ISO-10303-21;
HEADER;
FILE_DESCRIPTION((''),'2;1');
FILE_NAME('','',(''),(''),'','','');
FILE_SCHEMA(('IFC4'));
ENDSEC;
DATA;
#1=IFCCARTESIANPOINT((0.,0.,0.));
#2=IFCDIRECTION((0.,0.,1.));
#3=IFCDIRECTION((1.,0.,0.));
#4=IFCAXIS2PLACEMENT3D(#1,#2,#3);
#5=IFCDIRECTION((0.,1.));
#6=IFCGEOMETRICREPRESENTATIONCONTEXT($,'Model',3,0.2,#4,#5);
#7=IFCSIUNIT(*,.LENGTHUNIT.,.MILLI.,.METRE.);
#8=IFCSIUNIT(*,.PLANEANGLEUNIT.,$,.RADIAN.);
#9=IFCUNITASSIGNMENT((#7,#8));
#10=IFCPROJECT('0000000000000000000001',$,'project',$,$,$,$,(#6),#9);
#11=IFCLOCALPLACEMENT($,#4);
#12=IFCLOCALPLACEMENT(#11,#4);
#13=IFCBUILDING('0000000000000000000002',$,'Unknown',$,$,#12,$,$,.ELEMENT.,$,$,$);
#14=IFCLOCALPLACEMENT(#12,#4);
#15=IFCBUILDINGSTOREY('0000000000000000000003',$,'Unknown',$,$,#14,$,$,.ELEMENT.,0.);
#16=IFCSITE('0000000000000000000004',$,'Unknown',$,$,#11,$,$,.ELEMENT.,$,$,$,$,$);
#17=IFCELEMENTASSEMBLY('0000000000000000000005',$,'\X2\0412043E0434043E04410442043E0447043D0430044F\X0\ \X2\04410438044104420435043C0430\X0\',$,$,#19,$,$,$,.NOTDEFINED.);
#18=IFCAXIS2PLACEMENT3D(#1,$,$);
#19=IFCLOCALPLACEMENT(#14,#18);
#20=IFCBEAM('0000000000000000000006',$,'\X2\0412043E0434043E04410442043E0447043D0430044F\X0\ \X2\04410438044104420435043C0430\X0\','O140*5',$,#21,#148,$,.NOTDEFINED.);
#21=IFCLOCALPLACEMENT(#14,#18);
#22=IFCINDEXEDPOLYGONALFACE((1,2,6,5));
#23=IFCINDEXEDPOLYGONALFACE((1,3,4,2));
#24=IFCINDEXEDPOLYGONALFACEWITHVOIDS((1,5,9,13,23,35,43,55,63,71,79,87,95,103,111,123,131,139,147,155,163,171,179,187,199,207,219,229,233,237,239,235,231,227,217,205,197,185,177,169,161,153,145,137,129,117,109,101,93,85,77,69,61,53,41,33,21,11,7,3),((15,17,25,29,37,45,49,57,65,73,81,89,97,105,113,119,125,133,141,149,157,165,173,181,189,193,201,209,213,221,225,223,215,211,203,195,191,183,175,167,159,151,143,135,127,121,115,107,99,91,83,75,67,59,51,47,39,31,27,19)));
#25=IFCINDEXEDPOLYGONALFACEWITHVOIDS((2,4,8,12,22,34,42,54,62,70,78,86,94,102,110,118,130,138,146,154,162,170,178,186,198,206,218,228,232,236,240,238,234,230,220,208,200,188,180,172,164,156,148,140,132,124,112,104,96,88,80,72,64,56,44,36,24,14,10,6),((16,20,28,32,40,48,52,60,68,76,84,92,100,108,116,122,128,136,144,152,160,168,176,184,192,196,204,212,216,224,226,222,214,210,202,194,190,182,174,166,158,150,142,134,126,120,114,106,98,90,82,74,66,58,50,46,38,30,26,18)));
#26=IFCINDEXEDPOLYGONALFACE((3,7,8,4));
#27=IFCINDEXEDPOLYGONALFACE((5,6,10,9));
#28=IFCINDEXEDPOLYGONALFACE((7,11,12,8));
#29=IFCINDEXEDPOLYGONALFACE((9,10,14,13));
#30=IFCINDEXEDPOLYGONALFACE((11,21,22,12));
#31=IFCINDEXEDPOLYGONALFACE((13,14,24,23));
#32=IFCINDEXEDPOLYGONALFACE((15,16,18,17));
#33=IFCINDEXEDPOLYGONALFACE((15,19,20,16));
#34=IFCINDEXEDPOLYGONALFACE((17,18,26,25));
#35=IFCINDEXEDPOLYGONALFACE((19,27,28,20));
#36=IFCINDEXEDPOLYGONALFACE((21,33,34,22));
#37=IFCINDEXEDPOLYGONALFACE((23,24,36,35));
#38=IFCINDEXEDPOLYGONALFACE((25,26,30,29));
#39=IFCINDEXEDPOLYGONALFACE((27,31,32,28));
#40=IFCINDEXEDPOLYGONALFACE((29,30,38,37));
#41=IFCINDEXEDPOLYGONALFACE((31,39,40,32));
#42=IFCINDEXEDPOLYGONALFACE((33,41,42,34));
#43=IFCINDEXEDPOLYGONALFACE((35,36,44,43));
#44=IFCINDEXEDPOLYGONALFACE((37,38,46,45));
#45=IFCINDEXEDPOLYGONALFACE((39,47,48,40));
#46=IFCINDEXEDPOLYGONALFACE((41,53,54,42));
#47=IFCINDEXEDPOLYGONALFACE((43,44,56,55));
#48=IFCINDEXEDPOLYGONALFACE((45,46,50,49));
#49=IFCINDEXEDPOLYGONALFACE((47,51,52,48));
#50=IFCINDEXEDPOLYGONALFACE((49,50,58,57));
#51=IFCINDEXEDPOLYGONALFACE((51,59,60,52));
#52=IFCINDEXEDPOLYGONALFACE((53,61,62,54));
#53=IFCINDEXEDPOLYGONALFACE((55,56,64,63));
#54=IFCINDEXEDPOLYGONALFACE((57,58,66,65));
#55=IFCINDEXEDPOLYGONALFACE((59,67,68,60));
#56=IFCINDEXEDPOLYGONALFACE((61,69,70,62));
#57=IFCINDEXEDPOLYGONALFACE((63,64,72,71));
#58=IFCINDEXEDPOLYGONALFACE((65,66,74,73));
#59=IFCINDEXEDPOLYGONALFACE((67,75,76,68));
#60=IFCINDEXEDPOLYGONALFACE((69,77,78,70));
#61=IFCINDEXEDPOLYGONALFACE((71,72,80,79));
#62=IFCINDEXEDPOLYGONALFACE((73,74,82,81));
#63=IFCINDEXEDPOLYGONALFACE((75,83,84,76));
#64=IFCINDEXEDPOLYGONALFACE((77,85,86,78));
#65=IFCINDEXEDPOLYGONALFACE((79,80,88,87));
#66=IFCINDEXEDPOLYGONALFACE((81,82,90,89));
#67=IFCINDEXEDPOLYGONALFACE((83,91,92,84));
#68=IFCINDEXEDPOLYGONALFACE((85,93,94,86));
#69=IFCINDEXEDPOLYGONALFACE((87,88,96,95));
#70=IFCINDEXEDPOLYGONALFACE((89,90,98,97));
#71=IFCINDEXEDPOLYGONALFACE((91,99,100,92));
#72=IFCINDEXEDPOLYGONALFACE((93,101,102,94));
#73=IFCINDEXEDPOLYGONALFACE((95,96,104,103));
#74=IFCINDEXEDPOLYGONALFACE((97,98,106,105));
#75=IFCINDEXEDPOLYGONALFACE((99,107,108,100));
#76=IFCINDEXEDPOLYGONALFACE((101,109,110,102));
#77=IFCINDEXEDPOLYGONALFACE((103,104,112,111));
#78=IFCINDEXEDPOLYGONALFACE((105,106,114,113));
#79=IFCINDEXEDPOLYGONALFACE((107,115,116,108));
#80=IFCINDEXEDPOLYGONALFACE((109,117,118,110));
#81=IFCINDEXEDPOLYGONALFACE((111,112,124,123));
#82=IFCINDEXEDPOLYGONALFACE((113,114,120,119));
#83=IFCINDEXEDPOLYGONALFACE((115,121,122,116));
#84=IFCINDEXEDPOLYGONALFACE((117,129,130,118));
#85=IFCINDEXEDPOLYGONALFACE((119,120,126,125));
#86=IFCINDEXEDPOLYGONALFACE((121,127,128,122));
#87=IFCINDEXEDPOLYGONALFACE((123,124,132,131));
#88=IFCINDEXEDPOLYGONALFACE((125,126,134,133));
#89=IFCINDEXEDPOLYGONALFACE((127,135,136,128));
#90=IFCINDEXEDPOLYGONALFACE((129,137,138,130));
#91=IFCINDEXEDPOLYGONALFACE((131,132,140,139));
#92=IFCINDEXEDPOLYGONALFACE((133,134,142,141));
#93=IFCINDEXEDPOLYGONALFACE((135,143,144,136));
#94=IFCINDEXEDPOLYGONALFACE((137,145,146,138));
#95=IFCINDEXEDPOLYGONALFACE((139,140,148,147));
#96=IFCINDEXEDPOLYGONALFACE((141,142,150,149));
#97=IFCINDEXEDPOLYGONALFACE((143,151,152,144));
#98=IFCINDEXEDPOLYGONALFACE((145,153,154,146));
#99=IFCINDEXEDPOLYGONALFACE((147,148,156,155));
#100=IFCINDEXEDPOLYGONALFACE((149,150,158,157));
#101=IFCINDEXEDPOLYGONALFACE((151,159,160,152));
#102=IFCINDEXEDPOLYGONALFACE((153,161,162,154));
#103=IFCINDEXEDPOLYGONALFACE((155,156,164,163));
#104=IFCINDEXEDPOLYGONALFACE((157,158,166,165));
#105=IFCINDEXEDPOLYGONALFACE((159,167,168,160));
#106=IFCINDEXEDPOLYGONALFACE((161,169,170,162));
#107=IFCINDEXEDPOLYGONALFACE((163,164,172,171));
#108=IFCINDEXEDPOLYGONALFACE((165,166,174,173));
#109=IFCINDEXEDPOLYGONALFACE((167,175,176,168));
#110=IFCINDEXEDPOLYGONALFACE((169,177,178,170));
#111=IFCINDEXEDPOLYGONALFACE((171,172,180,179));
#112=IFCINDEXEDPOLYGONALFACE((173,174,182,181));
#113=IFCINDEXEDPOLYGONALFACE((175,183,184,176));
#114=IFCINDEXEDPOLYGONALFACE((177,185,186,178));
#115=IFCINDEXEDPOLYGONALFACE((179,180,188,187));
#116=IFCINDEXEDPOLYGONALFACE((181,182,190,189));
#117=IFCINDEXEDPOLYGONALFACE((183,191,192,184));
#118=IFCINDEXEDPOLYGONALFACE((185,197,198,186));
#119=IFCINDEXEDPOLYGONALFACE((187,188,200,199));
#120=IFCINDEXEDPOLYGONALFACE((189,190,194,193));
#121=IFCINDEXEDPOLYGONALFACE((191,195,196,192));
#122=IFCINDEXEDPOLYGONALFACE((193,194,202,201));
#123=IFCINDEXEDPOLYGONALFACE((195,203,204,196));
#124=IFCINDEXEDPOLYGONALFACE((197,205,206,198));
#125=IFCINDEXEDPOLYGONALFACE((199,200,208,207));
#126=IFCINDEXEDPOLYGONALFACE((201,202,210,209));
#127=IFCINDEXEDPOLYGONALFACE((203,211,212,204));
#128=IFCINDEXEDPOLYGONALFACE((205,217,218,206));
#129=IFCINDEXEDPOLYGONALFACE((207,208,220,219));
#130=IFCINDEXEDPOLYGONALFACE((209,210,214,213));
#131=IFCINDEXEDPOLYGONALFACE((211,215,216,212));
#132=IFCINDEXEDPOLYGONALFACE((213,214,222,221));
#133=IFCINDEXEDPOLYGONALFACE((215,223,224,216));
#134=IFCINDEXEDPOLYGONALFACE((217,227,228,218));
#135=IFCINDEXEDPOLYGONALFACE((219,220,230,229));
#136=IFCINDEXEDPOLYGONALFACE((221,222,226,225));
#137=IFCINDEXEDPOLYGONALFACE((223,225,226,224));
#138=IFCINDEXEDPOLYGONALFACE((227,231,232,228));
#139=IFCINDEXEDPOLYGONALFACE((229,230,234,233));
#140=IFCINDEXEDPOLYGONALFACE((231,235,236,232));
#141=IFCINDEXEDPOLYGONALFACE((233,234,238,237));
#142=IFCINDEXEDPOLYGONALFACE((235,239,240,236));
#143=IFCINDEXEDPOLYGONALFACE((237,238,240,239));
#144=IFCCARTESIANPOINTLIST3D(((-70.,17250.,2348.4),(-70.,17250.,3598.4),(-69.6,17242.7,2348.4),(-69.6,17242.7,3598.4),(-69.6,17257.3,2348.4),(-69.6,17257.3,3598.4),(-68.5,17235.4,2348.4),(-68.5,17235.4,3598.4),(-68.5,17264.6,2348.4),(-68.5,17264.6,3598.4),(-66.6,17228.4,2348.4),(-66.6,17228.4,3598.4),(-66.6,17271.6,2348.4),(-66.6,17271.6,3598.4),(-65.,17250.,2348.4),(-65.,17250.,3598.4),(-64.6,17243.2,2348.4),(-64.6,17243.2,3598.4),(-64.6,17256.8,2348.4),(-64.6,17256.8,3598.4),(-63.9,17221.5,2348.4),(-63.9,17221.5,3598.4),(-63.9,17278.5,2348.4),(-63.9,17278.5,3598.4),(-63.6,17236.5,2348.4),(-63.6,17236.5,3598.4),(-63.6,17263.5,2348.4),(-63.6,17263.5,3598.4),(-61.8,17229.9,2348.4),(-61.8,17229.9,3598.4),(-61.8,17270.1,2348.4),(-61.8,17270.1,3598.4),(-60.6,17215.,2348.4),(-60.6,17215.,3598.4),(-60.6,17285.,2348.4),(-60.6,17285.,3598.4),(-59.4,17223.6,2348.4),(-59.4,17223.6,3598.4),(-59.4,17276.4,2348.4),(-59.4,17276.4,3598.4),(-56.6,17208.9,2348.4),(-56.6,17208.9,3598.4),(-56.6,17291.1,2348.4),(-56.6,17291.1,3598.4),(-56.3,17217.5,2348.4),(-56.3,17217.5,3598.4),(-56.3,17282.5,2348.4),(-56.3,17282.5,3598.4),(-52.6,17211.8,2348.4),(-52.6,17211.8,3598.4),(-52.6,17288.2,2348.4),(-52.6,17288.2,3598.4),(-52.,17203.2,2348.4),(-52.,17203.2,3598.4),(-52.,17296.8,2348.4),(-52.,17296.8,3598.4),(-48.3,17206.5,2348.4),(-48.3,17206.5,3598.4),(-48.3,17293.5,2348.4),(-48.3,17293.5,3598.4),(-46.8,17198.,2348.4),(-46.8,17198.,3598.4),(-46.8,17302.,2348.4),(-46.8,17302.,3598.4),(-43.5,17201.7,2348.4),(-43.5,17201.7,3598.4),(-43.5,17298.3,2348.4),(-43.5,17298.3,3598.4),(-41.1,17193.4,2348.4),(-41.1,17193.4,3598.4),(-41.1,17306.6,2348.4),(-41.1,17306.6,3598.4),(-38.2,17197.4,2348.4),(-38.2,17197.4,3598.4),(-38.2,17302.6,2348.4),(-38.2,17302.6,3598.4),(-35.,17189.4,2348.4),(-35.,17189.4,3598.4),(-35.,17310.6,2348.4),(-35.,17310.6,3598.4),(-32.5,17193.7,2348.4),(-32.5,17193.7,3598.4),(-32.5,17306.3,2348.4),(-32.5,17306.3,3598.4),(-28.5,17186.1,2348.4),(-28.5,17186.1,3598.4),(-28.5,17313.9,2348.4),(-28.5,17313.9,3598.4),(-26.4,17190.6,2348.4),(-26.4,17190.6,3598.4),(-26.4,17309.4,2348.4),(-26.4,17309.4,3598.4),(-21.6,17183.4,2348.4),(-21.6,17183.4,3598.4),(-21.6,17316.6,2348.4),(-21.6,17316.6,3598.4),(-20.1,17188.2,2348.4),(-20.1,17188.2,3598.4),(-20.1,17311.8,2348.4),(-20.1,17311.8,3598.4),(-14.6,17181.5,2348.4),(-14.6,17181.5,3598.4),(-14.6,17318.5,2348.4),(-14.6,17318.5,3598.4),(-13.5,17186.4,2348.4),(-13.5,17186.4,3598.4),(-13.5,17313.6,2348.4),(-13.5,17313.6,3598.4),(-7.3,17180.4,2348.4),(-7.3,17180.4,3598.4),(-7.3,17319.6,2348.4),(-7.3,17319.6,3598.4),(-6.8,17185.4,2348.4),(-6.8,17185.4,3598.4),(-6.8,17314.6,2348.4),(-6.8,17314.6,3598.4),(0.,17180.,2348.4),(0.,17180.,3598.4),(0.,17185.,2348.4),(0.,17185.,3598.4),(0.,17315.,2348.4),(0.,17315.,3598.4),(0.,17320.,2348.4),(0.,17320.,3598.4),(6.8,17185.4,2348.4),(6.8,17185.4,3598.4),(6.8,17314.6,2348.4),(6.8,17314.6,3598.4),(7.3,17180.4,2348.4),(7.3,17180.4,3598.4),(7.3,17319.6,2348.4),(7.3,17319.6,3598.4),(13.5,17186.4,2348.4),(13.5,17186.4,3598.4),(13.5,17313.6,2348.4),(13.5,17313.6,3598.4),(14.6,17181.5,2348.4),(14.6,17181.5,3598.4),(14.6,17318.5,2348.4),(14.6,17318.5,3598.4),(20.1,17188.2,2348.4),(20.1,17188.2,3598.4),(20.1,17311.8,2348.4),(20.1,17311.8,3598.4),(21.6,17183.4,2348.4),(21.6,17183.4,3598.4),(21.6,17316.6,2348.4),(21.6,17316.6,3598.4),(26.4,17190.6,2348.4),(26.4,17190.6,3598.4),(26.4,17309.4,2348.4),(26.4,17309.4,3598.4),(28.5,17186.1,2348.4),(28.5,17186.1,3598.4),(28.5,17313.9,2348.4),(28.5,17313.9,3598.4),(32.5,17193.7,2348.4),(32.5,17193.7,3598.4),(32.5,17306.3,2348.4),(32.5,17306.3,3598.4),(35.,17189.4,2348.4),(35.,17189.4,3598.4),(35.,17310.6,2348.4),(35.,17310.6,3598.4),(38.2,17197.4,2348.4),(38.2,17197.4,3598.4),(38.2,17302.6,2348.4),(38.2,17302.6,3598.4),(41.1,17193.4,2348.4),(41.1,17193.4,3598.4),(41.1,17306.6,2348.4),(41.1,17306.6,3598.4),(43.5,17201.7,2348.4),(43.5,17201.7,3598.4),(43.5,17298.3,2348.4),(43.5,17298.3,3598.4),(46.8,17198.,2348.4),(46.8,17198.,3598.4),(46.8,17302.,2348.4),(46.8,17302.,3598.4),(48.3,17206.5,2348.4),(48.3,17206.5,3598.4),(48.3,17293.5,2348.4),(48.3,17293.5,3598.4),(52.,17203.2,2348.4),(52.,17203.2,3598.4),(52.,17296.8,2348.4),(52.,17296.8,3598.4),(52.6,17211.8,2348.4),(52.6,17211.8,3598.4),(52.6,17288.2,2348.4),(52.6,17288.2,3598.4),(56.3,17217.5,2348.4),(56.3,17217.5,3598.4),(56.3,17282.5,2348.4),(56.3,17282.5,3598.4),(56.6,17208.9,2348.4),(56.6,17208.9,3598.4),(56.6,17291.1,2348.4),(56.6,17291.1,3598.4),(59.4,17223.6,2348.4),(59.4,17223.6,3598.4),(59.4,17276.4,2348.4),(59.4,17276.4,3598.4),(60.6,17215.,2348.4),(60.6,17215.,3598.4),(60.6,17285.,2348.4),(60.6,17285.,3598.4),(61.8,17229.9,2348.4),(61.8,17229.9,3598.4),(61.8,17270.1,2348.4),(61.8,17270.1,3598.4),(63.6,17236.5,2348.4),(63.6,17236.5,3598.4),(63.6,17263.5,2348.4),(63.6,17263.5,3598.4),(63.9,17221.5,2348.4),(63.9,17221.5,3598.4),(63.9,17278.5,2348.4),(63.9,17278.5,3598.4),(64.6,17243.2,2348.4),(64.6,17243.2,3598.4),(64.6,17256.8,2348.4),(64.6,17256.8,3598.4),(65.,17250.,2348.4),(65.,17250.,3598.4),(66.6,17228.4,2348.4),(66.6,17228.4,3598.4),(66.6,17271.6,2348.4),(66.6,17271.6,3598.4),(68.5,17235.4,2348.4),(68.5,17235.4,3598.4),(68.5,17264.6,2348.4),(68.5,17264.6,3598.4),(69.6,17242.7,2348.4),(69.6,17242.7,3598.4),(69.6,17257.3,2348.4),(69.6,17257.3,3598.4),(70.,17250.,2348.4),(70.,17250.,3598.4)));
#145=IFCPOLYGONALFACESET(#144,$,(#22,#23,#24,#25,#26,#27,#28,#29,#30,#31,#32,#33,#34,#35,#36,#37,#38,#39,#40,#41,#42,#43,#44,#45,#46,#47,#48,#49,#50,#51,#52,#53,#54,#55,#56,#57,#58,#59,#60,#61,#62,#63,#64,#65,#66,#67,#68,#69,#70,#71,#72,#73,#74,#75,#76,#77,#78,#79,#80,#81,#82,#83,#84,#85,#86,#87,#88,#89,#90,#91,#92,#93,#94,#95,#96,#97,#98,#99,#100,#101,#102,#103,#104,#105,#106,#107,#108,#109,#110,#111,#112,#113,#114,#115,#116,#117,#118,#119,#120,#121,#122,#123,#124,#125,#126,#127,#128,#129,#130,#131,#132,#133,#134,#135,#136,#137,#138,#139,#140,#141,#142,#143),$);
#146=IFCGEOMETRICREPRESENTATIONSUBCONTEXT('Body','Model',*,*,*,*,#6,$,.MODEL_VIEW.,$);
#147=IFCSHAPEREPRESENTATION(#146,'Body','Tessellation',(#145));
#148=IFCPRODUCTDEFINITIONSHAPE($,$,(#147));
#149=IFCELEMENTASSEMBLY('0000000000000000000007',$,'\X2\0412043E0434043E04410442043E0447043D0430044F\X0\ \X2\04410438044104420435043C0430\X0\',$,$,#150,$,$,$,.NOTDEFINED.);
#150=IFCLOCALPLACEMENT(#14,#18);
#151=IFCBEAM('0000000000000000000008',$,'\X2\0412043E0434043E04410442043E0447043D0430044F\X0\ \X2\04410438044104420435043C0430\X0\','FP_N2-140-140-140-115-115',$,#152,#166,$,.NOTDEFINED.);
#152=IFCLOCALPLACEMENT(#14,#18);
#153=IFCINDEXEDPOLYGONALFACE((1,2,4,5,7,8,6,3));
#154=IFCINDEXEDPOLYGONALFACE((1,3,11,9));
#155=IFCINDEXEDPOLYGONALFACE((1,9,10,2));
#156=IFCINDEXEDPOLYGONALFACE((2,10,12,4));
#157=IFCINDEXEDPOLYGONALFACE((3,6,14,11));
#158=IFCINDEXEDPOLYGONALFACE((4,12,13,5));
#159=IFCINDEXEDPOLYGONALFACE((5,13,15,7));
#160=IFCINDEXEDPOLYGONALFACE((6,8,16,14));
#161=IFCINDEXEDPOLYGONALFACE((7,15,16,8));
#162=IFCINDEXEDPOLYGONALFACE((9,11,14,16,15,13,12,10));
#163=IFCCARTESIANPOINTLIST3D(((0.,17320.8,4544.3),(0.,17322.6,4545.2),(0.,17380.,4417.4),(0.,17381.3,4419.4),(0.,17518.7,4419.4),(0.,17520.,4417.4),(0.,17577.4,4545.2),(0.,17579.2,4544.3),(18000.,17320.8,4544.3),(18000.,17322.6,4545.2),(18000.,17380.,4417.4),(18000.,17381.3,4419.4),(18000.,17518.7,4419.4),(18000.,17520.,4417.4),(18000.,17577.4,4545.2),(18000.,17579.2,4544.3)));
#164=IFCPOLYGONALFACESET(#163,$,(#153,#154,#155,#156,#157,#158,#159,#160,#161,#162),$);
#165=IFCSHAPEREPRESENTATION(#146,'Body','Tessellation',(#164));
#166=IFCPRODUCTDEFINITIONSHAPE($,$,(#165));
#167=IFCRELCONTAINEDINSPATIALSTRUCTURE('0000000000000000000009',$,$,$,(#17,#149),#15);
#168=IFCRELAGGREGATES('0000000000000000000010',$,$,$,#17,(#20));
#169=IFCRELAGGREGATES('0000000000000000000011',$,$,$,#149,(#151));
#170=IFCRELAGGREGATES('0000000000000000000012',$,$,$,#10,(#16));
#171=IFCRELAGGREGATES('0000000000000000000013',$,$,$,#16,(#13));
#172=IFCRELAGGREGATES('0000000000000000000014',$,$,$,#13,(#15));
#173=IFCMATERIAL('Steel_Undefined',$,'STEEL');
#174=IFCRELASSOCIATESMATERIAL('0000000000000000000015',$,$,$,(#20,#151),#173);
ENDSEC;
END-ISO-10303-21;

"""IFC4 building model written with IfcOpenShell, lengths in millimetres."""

from ifc_helpers import new_model, si_unit, direction, frame, origin_with_axes, place, context, subcontext, project, spatial, line, indexed_curve, outline, extrude, material, element, aggregate, save


model = new_model("IFC4")

# Units and contexts
model_context = context("Model", 3, precision=0.2, world=origin_with_axes(), true_north=direction((0.0, 1.0)))
body_context = subcontext(model_context, "Body", "Model", "MODEL_VIEW")
ifc_project = project(units=[si_unit("LENGTHUNIT", "METRE", prefix="MILLI"), si_unit("PLANEANGLEUNIT", "RADIAN")], contexts=[model_context])

# Site, building, storey
site_placement = place(None, origin_with_axes())
site = spatial("IfcSite", under=ifc_project, at=site_placement, Name="Unknown", CompositionType="ELEMENT")
building_placement = place(site_placement, origin_with_axes())
building = spatial("IfcBuilding", under=site, at=building_placement, Name="Unknown", CompositionType="ELEMENT")
storey_placement = place(building_placement, origin_with_axes())
storey = spatial("IfcBuildingStorey", under=building, at=storey_placement, Name="Unknown", CompositionType="ELEMENT", Elevation=0.0)

# Element assemblies, beams
ifc_material_1 = material(Name="Steel_Undefined", Category="STEEL")
assembly_1_placement = place(storey_placement, frame((0.0, 17250.0, 3598.4), z_axis=(0.0, -1.0, 0.0), x_axis=(0.0, 0.0, -1.0)))
assembly_1 = element("IfcElementAssembly", 1, at=assembly_1_placement, inside=storey, Name="Водосточная система", PredefinedType="NOTDEFINED")
beam_1_placement = place(assembly_1_placement, origin_with_axes())
beam_1 = element("IfcBeam", 2, at=beam_1_placement, material=ifc_material_1, Name="Водосточная система", Description="O140*5", PredefinedType="NOTDEFINED", context=body_context, shape_type="SolidModel", body=[
    extrude(outline(indexed_curve([(70.0, 0.0), (69.6, 7.3), (68.5, 14.6), (66.6, 21.6), (63.9, 28.5), (60.6, 35.0), (56.6, 41.1), (52.0, 46.8), (46.8, 52.0), (41.1, 56.6), (35.0, 60.6), (28.5, 63.9), (21.6, 66.6), (14.6, 68.5), (7.3, 69.6), (0.0, 70.0), (-7.3, 69.6), (-14.6, 68.5), (-21.6, 66.6), (-28.5, 63.9), (-35.0, 60.6), (-41.1, 56.6), (-46.8, 52.0), (-52.0, 46.8), (-56.6, 41.1), (-60.6, 35.0), (-63.9, 28.5), (-66.6, 21.6), (-68.5, 14.6), (-69.6, 7.3), (-70.0, 0.0), (-69.6, -7.3), (-68.5, -14.6), (-66.6, -21.6), (-63.9, -28.5), (-60.6, -35.0), (-56.6, -41.1), (-52.0, -46.8), (-46.8, -52.0), (-41.1, -56.6), (-35.0, -60.6), (-28.5, -63.9), (-21.6, -66.6), (-14.6, -68.5), (-7.3, -69.6), (0.0, -70.0), (7.3, -69.6), (14.6, -68.5), (21.6, -66.6), (28.5, -63.9), (35.0, -60.6), (41.1, -56.6), (46.8, -52.0), (52.0, -46.8), (56.6, -41.1), (60.6, -35.0), (63.9, -28.5), (66.6, -21.6), (68.5, -14.6), (69.6, -7.3)], segments=[line(1, 2, 3, 4, 5, 6, 7, 8, 9, 10, 11, 12, 13, 14, 15, 16, 17, 18, 19, 20, 21, 22, 23, 24, 25, 26, 27, 28, 29, 30, 31, 32, 33, 34, 35, 36, 37, 38, 39, 40, 41, 42, 43, 44, 45, 46, 47, 48, 49, 50, 51, 52, 53, 54, 55, 56, 57, 58, 59, 60, 1)]), holes=[indexed_curve([(65.0, 0.0), (64.6, -6.8), (63.6, -13.5), (61.8, -20.1), (59.4, -26.4), (56.3, -32.5), (52.6, -38.2), (48.3, -43.5), (43.5, -48.3), (38.2, -52.6), (32.5, -56.3), (26.4, -59.4), (20.1, -61.8), (13.5, -63.6), (6.8, -64.6), (0.0, -65.0), (-6.8, -64.6), (-13.5, -63.6), (-20.1, -61.8), (-26.4, -59.4), (-32.5, -56.3), (-38.2, -52.6), (-43.5, -48.3), (-48.3, -43.5), (-52.6, -38.2), (-56.3, -32.5), (-59.4, -26.4), (-61.8, -20.1), (-63.6, -13.5), (-64.6, -6.8), (-65.0, 0.0), (-64.6, 6.8), (-63.6, 13.5), (-61.8, 20.1), (-59.4, 26.4), (-56.3, 32.5), (-52.6, 38.2), (-48.3, 43.5), (-43.5, 48.3), (-38.2, 52.6), (-32.5, 56.3), (-26.4, 59.4), (-20.1, 61.8), (-13.5, 63.6), (-6.8, 64.6), (0.0, 65.0), (6.8, 64.6), (13.5, 63.6), (20.1, 61.8), (26.4, 59.4), (32.5, 56.3), (38.2, 52.6), (43.5, 48.3), (48.3, 43.5), (52.6, 38.2), (56.3, 32.5), (59.4, 26.4), (61.8, 20.1), (63.6, 13.5), (64.6, 6.8)], segments=[line(1, 2, 3, 4, 5, 6, 7, 8, 9, 10, 11, 12, 13, 14, 15, 16, 17, 18, 19, 20, 21, 22, 23, 24, 25, 26, 27, 28, 29, 30, 31, 32, 33, 34, 35, 36, 37, 38, 39, 40, 41, 42, 43, 44, 45, 46, 47, 48, 49, 50, 51, 52, 53, 54, 55, 56, 57, 58, 59, 60, 1)])]), frame((0.0, 0.0, 0.0), z_axis=(-1.0, 0.0, 0.0), x_axis=(0.0, 0.0, 1.0)), (0.0, 0.0, -1.0), 1250.0),
])
aggregate(assembly_1, [beam_1])
assembly_2_placement = place(storey_placement, frame((0.0, 17450.0, 4418.4), z_axis=(0.0, -1.0, 0.0), x_axis=(1.0, 0.0, 0.0)))
assembly_2 = element("IfcElementAssembly", 3, at=assembly_2_placement, inside=storey, Name="Водосточная система", PredefinedType="NOTDEFINED")
beam_2_placement = place(assembly_2_placement, origin_with_axes())
beam_2 = element("IfcBeam", 4, at=beam_2_placement, material=ifc_material_1, Name="Водосточная система", Description="FP_N2-140-140-140-115-115", PredefinedType="NOTDEFINED", context=body_context, shape_type="SolidModel", body=[
    extrude(outline(indexed_curve([(-70.0, -1.0), (70.0, -1.0), (129.2, 125.9), (127.4, 126.7), (68.7, 1.0), (-68.7, 1.0), (-127.4, 126.7), (-129.2, 125.9)], segments=[line(1, 2, 3, 4, 5, 6, 7, 8, 1)])), frame((0.0, 0.0, 0.0), z_axis=(-1.0, 0.0, 0.0), x_axis=(0.0, 0.0, 1.0)), (0.0, 0.0, -1.0), 18000.0),
])
aggregate(assembly_2, [beam_2])

save(model, "model.ifc")
